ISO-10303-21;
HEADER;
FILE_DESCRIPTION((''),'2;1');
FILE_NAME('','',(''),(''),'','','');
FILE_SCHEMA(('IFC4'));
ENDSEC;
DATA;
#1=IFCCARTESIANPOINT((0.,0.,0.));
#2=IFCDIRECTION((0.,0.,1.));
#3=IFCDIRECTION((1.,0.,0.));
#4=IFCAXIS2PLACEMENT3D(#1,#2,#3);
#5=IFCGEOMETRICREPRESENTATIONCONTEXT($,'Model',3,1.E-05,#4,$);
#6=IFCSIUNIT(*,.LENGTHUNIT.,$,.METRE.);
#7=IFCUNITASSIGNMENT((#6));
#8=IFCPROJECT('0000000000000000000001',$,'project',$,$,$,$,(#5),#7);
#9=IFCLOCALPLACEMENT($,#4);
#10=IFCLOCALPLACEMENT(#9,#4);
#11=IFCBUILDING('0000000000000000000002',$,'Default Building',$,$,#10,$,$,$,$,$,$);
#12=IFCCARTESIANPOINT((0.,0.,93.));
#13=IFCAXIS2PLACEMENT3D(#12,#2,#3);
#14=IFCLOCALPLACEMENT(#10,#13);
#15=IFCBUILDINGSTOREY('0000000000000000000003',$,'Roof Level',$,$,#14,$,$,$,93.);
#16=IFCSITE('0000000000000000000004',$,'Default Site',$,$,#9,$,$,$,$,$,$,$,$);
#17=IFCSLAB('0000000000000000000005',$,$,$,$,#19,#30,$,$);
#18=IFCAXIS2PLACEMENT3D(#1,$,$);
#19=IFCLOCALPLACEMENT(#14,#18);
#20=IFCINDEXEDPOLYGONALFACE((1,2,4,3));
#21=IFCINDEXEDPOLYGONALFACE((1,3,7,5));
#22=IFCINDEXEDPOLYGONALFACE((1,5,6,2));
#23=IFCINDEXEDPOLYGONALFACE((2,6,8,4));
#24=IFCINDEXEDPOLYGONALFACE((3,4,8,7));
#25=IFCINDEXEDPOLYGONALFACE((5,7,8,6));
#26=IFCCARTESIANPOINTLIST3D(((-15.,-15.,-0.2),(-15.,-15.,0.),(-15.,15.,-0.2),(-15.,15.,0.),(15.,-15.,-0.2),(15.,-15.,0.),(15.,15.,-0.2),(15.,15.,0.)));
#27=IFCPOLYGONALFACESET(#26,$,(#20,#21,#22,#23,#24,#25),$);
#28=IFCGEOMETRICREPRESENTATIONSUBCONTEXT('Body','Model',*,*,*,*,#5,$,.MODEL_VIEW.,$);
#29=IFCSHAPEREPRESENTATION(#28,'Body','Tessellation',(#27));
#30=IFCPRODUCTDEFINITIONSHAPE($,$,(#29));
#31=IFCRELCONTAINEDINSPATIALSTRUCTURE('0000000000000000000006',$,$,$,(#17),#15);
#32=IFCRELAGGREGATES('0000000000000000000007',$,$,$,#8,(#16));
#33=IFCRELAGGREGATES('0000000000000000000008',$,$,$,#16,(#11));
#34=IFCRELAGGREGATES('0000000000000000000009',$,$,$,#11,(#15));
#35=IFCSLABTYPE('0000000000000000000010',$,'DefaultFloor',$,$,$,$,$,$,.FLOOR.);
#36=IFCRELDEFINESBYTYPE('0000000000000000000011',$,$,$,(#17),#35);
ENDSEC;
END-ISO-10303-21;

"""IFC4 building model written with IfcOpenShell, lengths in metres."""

from ifc_helpers import new_model, si_unit, frame, origin_with_axes, place, context, subcontext, project, spatial, polyline, outline, extrude, type_object, element, save


model = new_model("IFC4")

# Units and contexts
model_context = context("Model", 3, precision=1e-05, world=origin_with_axes())
body_context = subcontext(model_context, "Body", "Model", "MODEL_VIEW")
ifc_project = project(units=[si_unit("LENGTHUNIT", "METRE")], contexts=[model_context])

# Site, building, storey
site_placement = place(None, origin_with_axes())
site = spatial("IfcSite", under=ifc_project, at=site_placement, Name="Default Site")
building_placement = place(site_placement, origin_with_axes())
building = spatial("IfcBuilding", under=site, at=building_placement, Name="Default Building")
storey_placement = place(building_placement, frame((0.0, 0.0, 93.0), z_axis=(0.0, 0.0, 1.0), x_axis=(1.0, 0.0, 0.0)))
storey = spatial("IfcBuildingStorey", under=building, at=storey_placement, Name="Roof Level", Elevation=93.0)

# Slab
slab_type = type_object("IfcSlabType", Name="DefaultFloor", PredefinedType="FLOOR")
slab_placement = place(storey_placement, frame((0.0, 0.0, -93.0), z_axis=(0.0, 0.0, 1.0), x_axis=(1.0, 0.0, 0.0)))
element("IfcSlab", 1, at=slab_placement, inside=storey, type_object=slab_type, context=body_context, shape_type="SweptSolid", body=[
    extrude(outline(polyline([(-15.0, 15.0), (-15.0, -15.0), (15.0, -15.0), (15.0, 15.0), (-15.0, 15.0)])), frame((0.0, 0.0, 93.0), z_axis=(0.0, 0.0, 1.0), x_axis=(1.0, 0.0, 0.0)), (0.0, 0.0, -1.0), 0.2),
])

save(model, "model.ifc")
